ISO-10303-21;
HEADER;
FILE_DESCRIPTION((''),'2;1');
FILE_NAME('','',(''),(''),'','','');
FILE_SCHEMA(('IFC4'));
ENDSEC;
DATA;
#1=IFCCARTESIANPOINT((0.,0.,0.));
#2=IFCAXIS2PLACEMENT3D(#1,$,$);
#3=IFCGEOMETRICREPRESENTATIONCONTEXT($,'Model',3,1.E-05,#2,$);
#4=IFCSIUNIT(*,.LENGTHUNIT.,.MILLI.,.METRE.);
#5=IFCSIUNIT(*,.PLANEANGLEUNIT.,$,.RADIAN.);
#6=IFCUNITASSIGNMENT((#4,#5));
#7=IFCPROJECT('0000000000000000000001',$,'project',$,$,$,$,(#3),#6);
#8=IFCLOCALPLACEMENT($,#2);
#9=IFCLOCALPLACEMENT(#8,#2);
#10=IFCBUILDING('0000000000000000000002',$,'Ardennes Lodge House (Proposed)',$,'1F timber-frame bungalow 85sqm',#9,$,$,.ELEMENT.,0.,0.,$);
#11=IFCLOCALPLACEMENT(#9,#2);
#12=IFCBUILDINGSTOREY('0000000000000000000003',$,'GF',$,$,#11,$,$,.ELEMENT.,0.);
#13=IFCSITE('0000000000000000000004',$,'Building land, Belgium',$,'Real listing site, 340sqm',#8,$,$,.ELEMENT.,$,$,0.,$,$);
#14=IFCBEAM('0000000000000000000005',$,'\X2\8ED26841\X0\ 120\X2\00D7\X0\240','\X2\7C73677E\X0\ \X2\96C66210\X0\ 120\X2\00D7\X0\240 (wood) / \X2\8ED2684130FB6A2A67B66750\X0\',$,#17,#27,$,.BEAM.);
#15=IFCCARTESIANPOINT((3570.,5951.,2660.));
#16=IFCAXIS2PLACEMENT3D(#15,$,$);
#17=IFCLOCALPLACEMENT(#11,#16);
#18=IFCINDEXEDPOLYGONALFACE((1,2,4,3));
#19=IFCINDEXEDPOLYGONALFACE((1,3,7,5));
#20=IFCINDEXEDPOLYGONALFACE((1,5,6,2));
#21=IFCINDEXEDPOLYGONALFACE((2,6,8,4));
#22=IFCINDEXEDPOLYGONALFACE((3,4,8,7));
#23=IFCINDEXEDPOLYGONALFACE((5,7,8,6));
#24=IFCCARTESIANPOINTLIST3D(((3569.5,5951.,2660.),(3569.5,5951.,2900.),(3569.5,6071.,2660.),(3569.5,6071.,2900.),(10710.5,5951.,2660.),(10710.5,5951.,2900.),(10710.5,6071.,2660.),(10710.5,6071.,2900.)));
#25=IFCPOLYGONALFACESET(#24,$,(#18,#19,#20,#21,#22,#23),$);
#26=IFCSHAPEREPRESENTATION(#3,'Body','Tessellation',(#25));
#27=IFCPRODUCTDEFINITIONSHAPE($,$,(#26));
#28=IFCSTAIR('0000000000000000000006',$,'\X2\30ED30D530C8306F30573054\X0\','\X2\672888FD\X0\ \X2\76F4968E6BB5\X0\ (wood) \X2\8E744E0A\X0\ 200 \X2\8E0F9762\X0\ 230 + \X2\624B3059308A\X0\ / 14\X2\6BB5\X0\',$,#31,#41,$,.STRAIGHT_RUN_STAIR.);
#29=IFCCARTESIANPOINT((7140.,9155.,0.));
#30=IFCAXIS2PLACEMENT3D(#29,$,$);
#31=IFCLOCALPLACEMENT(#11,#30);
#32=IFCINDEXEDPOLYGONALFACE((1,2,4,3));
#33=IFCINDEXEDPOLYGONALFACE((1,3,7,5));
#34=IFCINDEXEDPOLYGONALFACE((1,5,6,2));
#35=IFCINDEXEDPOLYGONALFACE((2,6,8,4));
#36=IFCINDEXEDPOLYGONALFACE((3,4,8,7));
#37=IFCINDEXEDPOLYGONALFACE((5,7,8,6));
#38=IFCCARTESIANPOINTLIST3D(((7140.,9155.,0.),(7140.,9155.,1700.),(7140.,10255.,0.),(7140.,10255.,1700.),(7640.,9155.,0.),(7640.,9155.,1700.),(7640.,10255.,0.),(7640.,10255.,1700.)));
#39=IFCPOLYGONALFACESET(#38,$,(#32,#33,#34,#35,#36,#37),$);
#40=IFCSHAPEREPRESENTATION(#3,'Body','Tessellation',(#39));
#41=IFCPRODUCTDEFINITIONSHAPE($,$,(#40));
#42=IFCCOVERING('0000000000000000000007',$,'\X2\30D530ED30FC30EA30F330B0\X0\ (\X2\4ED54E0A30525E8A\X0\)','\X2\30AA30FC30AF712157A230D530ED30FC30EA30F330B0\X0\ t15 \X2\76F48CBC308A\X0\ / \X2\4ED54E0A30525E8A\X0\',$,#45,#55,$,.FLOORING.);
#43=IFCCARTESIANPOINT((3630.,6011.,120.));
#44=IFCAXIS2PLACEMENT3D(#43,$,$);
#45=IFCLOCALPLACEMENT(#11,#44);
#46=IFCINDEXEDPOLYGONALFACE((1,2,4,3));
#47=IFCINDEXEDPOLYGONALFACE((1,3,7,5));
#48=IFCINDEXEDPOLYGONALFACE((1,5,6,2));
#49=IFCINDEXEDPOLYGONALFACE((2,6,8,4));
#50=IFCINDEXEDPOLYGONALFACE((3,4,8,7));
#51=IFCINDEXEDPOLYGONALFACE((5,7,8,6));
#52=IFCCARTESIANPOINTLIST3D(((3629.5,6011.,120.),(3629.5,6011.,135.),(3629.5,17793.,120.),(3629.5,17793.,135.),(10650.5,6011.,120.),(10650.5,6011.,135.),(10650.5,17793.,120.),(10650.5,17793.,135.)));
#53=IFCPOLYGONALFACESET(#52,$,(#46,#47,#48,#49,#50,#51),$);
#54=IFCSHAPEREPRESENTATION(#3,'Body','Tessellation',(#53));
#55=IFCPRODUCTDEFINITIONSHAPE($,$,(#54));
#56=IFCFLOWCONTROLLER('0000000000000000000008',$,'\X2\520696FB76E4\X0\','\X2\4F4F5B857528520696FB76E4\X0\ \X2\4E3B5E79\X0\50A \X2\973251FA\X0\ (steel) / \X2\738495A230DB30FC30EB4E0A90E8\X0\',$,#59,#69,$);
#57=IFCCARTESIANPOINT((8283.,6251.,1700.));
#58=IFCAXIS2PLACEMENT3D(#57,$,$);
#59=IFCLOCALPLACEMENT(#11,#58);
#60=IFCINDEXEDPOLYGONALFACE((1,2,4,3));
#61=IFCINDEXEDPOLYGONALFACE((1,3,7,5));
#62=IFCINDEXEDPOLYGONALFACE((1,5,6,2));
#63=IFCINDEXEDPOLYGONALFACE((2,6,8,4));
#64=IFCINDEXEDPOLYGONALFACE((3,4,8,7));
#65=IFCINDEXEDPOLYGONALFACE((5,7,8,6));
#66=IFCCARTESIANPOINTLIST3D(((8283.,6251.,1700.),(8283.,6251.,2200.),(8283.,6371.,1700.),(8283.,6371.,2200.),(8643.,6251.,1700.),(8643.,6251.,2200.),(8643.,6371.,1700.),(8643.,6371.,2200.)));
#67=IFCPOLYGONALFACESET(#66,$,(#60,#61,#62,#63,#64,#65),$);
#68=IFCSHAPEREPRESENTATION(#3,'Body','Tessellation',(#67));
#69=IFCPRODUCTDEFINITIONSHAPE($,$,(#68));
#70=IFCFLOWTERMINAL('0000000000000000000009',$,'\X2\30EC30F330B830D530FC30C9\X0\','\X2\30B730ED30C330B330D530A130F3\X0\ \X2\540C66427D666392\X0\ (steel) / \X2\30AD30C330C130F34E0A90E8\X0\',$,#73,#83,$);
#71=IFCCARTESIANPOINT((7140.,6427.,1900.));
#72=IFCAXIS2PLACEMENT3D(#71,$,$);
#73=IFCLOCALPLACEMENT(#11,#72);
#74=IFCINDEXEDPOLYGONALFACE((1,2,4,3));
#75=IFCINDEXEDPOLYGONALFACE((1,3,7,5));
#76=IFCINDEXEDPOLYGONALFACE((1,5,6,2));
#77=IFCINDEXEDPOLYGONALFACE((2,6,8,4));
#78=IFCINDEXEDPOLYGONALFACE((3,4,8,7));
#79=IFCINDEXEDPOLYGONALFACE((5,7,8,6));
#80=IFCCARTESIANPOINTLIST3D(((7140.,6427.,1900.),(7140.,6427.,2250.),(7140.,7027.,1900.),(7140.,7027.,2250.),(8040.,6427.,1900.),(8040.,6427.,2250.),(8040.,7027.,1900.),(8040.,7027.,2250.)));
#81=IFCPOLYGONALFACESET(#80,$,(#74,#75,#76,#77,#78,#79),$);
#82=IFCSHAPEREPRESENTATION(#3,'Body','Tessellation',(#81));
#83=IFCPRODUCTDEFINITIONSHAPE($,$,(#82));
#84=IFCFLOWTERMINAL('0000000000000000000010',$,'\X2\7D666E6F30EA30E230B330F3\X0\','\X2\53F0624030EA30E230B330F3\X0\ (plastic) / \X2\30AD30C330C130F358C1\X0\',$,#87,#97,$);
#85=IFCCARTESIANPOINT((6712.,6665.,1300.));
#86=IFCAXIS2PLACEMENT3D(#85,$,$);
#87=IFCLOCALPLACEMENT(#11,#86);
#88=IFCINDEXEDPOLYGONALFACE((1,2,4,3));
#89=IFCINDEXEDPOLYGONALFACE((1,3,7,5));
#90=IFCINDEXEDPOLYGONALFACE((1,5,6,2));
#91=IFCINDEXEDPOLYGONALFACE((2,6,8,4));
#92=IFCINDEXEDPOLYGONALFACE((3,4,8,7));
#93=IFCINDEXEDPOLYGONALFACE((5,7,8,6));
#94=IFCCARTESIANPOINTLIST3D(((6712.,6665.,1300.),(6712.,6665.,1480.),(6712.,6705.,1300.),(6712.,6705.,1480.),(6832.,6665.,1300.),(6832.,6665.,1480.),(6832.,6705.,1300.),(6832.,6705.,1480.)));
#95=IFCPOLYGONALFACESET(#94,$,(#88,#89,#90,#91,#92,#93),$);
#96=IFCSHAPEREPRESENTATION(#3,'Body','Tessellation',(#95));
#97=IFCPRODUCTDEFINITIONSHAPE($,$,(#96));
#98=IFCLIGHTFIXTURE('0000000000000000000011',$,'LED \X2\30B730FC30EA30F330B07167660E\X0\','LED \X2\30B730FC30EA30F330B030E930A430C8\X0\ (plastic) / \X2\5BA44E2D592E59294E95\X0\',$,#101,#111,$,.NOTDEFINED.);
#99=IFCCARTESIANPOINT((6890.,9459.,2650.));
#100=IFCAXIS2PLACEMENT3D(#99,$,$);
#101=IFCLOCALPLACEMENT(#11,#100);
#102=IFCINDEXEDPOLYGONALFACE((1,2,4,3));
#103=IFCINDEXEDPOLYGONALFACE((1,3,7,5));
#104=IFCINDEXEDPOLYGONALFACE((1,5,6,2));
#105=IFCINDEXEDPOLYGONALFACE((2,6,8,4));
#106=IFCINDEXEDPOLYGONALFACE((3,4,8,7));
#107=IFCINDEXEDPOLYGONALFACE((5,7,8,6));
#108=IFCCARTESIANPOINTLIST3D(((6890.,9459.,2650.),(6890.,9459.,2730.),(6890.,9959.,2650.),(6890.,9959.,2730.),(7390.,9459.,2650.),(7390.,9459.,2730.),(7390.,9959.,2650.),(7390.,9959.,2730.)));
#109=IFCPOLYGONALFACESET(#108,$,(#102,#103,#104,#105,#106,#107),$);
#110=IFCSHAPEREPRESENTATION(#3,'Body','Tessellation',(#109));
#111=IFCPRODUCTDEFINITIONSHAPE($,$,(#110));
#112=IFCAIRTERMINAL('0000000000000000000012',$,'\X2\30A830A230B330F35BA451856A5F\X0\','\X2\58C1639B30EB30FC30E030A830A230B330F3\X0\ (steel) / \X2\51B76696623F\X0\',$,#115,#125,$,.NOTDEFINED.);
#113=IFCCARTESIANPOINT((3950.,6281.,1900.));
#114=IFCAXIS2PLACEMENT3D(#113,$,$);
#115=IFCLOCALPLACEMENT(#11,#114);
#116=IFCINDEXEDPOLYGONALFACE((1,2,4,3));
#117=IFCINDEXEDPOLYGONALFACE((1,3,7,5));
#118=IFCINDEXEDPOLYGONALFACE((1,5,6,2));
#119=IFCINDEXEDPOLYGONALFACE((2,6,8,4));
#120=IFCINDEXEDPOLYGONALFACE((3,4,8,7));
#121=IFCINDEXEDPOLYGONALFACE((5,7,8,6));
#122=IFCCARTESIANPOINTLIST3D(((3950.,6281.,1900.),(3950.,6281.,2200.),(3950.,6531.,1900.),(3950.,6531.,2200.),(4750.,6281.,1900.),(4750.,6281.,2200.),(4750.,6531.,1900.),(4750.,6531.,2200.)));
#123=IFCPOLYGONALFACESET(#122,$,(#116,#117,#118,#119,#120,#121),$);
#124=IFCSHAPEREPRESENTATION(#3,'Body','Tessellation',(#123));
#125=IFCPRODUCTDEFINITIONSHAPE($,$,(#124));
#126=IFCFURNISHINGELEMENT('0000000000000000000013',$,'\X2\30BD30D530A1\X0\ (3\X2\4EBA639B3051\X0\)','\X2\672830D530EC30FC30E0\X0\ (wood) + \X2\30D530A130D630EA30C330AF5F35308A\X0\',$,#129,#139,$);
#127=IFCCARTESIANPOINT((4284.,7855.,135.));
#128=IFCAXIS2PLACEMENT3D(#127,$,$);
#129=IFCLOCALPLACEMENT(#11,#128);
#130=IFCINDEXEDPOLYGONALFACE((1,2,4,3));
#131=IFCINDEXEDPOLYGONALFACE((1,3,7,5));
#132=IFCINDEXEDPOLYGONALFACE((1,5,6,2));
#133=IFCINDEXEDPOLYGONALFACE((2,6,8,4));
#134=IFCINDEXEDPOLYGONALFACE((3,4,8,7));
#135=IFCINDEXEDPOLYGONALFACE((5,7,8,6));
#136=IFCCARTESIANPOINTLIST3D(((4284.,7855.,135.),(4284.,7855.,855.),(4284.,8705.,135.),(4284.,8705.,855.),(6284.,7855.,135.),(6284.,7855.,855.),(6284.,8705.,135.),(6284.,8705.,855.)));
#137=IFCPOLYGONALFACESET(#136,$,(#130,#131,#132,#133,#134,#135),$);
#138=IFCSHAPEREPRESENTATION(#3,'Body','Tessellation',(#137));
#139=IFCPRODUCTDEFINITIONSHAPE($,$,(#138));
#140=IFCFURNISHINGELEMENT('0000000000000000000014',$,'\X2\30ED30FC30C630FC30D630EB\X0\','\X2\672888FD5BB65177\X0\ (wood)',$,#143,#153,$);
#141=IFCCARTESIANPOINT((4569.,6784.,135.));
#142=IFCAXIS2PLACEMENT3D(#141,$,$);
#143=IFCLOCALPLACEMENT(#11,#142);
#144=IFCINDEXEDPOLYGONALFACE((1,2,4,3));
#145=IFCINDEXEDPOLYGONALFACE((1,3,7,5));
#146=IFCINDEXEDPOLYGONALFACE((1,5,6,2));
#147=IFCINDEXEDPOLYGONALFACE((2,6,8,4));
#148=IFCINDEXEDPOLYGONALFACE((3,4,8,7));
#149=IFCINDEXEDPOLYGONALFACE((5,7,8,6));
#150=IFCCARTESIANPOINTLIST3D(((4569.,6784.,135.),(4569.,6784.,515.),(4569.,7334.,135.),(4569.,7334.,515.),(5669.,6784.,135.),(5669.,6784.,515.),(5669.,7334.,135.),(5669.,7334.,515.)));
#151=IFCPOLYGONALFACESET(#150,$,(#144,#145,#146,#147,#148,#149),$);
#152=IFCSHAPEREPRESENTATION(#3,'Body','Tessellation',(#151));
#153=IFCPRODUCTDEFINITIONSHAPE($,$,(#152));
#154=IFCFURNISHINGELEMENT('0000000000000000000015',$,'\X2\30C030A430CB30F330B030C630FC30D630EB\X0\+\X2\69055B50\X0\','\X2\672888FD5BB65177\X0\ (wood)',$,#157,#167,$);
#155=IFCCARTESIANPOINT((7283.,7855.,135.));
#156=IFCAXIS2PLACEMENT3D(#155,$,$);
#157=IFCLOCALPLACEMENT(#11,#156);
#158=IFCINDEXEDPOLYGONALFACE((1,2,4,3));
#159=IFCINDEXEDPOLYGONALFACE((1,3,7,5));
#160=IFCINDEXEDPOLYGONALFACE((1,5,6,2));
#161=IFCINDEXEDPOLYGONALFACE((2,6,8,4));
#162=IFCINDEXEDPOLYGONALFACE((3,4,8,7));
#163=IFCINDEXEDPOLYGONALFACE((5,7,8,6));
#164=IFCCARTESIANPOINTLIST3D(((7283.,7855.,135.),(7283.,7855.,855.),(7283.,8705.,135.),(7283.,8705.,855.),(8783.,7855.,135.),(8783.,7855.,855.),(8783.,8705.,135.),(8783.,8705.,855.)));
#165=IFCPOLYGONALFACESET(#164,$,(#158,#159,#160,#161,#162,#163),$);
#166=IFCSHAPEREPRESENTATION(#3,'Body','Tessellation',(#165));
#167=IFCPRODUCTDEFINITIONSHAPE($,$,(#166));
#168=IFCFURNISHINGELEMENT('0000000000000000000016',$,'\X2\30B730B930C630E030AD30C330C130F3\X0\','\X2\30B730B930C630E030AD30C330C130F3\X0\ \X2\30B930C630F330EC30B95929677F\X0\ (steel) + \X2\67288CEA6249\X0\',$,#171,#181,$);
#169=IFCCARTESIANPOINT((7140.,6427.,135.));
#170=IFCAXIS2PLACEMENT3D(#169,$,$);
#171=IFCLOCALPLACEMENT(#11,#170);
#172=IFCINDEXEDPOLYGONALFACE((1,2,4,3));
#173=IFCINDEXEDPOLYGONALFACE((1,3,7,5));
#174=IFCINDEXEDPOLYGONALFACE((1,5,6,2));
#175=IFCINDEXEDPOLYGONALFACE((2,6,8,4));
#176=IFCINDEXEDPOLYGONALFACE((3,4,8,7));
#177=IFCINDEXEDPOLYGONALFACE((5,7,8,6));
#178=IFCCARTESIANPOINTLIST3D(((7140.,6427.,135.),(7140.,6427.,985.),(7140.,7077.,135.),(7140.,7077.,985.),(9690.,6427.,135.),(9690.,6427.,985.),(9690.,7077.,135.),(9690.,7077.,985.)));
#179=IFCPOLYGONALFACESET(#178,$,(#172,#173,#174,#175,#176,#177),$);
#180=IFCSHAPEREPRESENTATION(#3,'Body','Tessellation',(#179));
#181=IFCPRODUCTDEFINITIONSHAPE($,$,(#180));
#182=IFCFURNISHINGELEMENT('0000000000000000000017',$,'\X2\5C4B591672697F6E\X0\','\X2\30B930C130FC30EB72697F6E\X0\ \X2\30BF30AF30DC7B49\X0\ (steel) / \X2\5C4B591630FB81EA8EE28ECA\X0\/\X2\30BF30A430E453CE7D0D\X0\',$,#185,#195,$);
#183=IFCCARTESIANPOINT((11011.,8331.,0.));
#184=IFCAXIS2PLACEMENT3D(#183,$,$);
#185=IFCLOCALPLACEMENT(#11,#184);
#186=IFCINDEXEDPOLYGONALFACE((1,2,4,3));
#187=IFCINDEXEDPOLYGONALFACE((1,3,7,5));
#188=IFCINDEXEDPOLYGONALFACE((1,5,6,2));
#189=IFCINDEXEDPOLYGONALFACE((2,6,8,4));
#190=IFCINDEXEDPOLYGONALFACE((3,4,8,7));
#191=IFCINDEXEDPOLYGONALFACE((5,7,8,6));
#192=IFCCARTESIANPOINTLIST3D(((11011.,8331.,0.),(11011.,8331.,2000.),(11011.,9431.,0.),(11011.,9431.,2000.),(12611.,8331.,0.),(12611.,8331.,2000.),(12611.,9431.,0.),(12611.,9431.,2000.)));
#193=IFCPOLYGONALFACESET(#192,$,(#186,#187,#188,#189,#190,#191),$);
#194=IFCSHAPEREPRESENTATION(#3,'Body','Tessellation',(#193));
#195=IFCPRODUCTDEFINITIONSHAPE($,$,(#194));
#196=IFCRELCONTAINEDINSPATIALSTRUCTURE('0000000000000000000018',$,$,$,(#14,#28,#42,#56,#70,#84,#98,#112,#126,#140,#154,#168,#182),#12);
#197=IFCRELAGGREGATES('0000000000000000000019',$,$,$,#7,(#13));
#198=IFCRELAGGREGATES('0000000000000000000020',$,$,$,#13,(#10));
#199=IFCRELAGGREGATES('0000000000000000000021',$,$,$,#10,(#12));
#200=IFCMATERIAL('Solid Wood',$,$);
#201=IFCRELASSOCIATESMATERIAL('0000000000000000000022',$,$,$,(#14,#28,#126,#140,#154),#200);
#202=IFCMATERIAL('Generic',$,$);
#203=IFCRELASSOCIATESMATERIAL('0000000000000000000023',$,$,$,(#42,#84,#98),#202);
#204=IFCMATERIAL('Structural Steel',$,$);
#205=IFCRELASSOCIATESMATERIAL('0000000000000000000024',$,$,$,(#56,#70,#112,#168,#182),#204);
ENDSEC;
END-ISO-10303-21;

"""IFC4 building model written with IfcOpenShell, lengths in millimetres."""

from ifc_helpers import new_model, si_unit, frame, frame_2d, origin, place, context, project, spatial, rectangle, extrude, material, element, save


model = new_model("IFC4")

# Units and contexts
model_context = context("Model", 3, precision=1e-05, world=origin())
ifc_project = project(units=[si_unit("LENGTHUNIT", "METRE", prefix="MILLI"), si_unit("PLANEANGLEUNIT", "RADIAN")], contexts=[model_context])

# Site, building, storey
site_placement = place(None, origin())
site = spatial("IfcSite", under=ifc_project, at=site_placement, Name="Building land, Belgium", ObjectType="Real listing site, 340sqm", CompositionType="ELEMENT", RefElevation=0.0)
building_placement = place(site_placement, origin())
building = spatial("IfcBuilding", under=site, at=building_placement, Name="Ardennes Lodge House (Proposed)", ObjectType="1F timber-frame bungalow 85sqm", CompositionType="ELEMENT", ElevationOfRefHeight=0.0, ElevationOfTerrain=0.0)
storey_placement = place(building_placement, origin())
storey = spatial("IfcBuildingStorey", under=building, at=storey_placement, Name="GF", CompositionType="ELEMENT", Elevation=0.0)

# Shared definitions
ifc_material_1 = material(Name="Solid Wood")

# Beam
beam_1_placement = place(storey_placement, frame((3570.0, 5951.0, 2660.0)))
element("IfcBeam", 1, at=beam_1_placement, inside=storey, material=ifc_material_1, Name="軒桁 120×240", Description="米松 集成 120×240 (wood) / 軒桁・横架材", PredefinedType="BEAM", context=model_context, shape_type="SweptSolid", body=[
    extrude(rectangle(XDim=7141.0, YDim=120.0, at=frame_2d((3570.0, 60.0))), frame((3570.0, 5951.0, 2660.0)), (0.0, 0.0, 1.0), 240.0),
])

# Stair
stair_placement = place(storey_placement, frame((7140.0, 9155.0, 0.0)))
element("IfcStair", 2, at=stair_placement, inside=storey, material=ifc_material_1, Name="ロフトはしご", Description="木製 直階段 (wood) 蹴上 200 踏面 230 + 手すり / 14段", PredefinedType="STRAIGHT_RUN_STAIR", context=model_context, shape_type="SweptSolid", body=[
    extrude(rectangle(XDim=500.0, YDim=1100.0, at=frame_2d((250.0, 550.0))), frame((7140.0, 9155.0, 0.0)), (0.0, 0.0, 1.0), 1700.0),
])

# Covering
ifc_material_2 = material(Name="Generic")
covering_placement = place(storey_placement, frame((3630.0, 6011.0, 120.0)))
element("IfcCovering", 3, at=covering_placement, inside=storey, material=ifc_material_2, Name="フローリング (仕上げ床)", Description="オーク無垢フローリング t15 直貼り / 仕上げ床", PredefinedType="FLOORING", context=model_context, shape_type="SweptSolid", body=[
    extrude(rectangle(XDim=7021.0, YDim=11782.0, at=frame_2d((3510.0, 5891.0))), frame((3630.0, 6011.0, 120.0)), (0.0, 0.0, 1.0), 15.0),
])

# Flow controller
ifc_material_3 = material(Name="Structural Steel")
flow_controller_placement = place(storey_placement, frame((8283.0, 6251.0, 1700.0)))
element("IfcFlowController", 4, at=flow_controller_placement, inside=storey, material=ifc_material_3, Name="分電盤", Description="住宅用分電盤 主幹50A 露出 (steel) / 玄関ホール上部", context=model_context, shape_type="SweptSolid", body=[
    extrude(rectangle(XDim=360.0, YDim=120.0, at=frame_2d((180.0, 60.0))), frame((8283.0, 6251.0, 1700.0)), (0.0, 0.0, 1.0), 500.0),
])

# Flow terminals
flow_terminal_1_placement = place(storey_placement, frame((7140.0, 6427.0, 1900.0)))
element("IfcFlowTerminal", 5, at=flow_terminal_1_placement, inside=storey, material=ifc_material_3, Name="レンジフード", Description="シロッコファン 同時給排 (steel) / キッチン上部", context=model_context, shape_type="SweptSolid", body=[
    extrude(rectangle(XDim=900.0, YDim=600.0, at=frame_2d((450.0, 300.0))), frame((7140.0, 6427.0, 1900.0)), (0.0, 0.0, 1.0), 350.0),
])
flow_terminal_2_placement = place(storey_placement, frame((6712.0, 6665.0, 1300.0)))
element("IfcFlowTerminal", 6, at=flow_terminal_2_placement, inside=storey, material=ifc_material_2, Name="給湯リモコン", Description="台所リモコン (plastic) / キッチン壁", context=model_context, shape_type="SweptSolid", body=[
    extrude(rectangle(XDim=120.0, YDim=40.0, at=frame_2d((60.0, 20.0))), frame((6712.0, 6665.0, 1300.0)), (0.0, 0.0, 1.0), 180.0),
])

# Light fixture
light_fixture_placement = place(storey_placement, frame((6890.0, 9459.0, 2650.0)))
element("IfcLightFixture", 7, at=light_fixture_placement, inside=storey, material=ifc_material_2, Name="LED シーリング照明", Description="LED シーリングライト (plastic) / 室中央天井", PredefinedType="NOTDEFINED", context=model_context, shape_type="SweptSolid", body=[
    extrude(rectangle(XDim=500.0, YDim=500.0, at=frame_2d((250.0, 250.0))), frame((6890.0, 9459.0, 2650.0)), (0.0, 0.0, 1.0), 80.0),
])

# Air terminal
air_terminal_placement = place(storey_placement, frame((3950.0, 6281.0, 1900.0)))
element("IfcAirTerminal", 8, at=air_terminal_placement, inside=storey, material=ifc_material_3, Name="エアコン室内機", Description="壁掛ルームエアコン (steel) / 冷暖房", PredefinedType="NOTDEFINED", context=model_context, shape_type="SweptSolid", body=[
    extrude(rectangle(XDim=800.0, YDim=250.0, at=frame_2d((400.0, 125.0))), frame((3950.0, 6281.0, 1900.0)), (0.0, 0.0, 1.0), 300.0),
])

# Furnishing elements
furnishing_1_placement = place(storey_placement, frame((4284.0, 7855.0, 135.0)))
element("IfcFurnishingElement", 9, at=furnishing_1_placement, inside=storey, material=ifc_material_1, Name="ソファ (3人掛け)", Description="木フレーム (wood) + ファブリック張り", context=model_context, shape_type="SweptSolid", body=[
    extrude(rectangle(XDim=2000.0, YDim=850.0, at=frame_2d((1000.0, 425.0))), frame((4284.0, 7855.0, 135.0)), (0.0, 0.0, 1.0), 720.0),
])
furnishing_2_placement = place(storey_placement, frame((4569.0, 6784.0, 135.0)))
element("IfcFurnishingElement", 10, at=furnishing_2_placement, inside=storey, material=ifc_material_1, Name="ローテーブル", Description="木製家具 (wood)", context=model_context, shape_type="SweptSolid", body=[
    extrude(rectangle(XDim=1100.0, YDim=550.0, at=frame_2d((550.0, 275.0))), frame((4569.0, 6784.0, 135.0)), (0.0, 0.0, 1.0), 380.0),
])
furnishing_3_placement = place(storey_placement, frame((7283.0, 7855.0, 135.0)))
element("IfcFurnishingElement", 11, at=furnishing_3_placement, inside=storey, material=ifc_material_1, Name="ダイニングテーブル+椅子", Description="木製家具 (wood)", context=model_context, shape_type="SweptSolid", body=[
    extrude(rectangle(XDim=1500.0, YDim=850.0, at=frame_2d((750.0, 425.0))), frame((7283.0, 7855.0, 135.0)), (0.0, 0.0, 1.0), 720.0),
])
furnishing_4_placement = place(storey_placement, frame((7140.0, 6427.0, 135.0)))
element("IfcFurnishingElement", 12, at=furnishing_4_placement, inside=storey, material=ifc_material_3, Name="システムキッチン", Description="システムキッチン ステンレス天板 (steel) + 木質扉", context=model_context, shape_type="SweptSolid", body=[
    extrude(rectangle(XDim=2550.0, YDim=650.0, at=frame_2d((1275.0, 325.0))), frame((7140.0, 6427.0, 135.0)), (0.0, 0.0, 1.0), 850.0),
])
furnishing_5_placement = place(storey_placement, frame((11011.0, 8331.0, 0.0)))
element("IfcFurnishingElement", 13, at=furnishing_5_placement, inside=storey, material=ifc_material_3, Name="屋外物置", Description="スチール物置 タクボ等 (steel) / 屋外・自転車/タイヤ収納", context=model_context, shape_type="SweptSolid", body=[
    extrude(rectangle(XDim=1600.0, YDim=1100.0, at=frame_2d((800.0, 550.0))), frame((11011.0, 8331.0, 0.0)), (0.0, 0.0, 1.0), 2000.0),
])

save(model, "model.ifc")
